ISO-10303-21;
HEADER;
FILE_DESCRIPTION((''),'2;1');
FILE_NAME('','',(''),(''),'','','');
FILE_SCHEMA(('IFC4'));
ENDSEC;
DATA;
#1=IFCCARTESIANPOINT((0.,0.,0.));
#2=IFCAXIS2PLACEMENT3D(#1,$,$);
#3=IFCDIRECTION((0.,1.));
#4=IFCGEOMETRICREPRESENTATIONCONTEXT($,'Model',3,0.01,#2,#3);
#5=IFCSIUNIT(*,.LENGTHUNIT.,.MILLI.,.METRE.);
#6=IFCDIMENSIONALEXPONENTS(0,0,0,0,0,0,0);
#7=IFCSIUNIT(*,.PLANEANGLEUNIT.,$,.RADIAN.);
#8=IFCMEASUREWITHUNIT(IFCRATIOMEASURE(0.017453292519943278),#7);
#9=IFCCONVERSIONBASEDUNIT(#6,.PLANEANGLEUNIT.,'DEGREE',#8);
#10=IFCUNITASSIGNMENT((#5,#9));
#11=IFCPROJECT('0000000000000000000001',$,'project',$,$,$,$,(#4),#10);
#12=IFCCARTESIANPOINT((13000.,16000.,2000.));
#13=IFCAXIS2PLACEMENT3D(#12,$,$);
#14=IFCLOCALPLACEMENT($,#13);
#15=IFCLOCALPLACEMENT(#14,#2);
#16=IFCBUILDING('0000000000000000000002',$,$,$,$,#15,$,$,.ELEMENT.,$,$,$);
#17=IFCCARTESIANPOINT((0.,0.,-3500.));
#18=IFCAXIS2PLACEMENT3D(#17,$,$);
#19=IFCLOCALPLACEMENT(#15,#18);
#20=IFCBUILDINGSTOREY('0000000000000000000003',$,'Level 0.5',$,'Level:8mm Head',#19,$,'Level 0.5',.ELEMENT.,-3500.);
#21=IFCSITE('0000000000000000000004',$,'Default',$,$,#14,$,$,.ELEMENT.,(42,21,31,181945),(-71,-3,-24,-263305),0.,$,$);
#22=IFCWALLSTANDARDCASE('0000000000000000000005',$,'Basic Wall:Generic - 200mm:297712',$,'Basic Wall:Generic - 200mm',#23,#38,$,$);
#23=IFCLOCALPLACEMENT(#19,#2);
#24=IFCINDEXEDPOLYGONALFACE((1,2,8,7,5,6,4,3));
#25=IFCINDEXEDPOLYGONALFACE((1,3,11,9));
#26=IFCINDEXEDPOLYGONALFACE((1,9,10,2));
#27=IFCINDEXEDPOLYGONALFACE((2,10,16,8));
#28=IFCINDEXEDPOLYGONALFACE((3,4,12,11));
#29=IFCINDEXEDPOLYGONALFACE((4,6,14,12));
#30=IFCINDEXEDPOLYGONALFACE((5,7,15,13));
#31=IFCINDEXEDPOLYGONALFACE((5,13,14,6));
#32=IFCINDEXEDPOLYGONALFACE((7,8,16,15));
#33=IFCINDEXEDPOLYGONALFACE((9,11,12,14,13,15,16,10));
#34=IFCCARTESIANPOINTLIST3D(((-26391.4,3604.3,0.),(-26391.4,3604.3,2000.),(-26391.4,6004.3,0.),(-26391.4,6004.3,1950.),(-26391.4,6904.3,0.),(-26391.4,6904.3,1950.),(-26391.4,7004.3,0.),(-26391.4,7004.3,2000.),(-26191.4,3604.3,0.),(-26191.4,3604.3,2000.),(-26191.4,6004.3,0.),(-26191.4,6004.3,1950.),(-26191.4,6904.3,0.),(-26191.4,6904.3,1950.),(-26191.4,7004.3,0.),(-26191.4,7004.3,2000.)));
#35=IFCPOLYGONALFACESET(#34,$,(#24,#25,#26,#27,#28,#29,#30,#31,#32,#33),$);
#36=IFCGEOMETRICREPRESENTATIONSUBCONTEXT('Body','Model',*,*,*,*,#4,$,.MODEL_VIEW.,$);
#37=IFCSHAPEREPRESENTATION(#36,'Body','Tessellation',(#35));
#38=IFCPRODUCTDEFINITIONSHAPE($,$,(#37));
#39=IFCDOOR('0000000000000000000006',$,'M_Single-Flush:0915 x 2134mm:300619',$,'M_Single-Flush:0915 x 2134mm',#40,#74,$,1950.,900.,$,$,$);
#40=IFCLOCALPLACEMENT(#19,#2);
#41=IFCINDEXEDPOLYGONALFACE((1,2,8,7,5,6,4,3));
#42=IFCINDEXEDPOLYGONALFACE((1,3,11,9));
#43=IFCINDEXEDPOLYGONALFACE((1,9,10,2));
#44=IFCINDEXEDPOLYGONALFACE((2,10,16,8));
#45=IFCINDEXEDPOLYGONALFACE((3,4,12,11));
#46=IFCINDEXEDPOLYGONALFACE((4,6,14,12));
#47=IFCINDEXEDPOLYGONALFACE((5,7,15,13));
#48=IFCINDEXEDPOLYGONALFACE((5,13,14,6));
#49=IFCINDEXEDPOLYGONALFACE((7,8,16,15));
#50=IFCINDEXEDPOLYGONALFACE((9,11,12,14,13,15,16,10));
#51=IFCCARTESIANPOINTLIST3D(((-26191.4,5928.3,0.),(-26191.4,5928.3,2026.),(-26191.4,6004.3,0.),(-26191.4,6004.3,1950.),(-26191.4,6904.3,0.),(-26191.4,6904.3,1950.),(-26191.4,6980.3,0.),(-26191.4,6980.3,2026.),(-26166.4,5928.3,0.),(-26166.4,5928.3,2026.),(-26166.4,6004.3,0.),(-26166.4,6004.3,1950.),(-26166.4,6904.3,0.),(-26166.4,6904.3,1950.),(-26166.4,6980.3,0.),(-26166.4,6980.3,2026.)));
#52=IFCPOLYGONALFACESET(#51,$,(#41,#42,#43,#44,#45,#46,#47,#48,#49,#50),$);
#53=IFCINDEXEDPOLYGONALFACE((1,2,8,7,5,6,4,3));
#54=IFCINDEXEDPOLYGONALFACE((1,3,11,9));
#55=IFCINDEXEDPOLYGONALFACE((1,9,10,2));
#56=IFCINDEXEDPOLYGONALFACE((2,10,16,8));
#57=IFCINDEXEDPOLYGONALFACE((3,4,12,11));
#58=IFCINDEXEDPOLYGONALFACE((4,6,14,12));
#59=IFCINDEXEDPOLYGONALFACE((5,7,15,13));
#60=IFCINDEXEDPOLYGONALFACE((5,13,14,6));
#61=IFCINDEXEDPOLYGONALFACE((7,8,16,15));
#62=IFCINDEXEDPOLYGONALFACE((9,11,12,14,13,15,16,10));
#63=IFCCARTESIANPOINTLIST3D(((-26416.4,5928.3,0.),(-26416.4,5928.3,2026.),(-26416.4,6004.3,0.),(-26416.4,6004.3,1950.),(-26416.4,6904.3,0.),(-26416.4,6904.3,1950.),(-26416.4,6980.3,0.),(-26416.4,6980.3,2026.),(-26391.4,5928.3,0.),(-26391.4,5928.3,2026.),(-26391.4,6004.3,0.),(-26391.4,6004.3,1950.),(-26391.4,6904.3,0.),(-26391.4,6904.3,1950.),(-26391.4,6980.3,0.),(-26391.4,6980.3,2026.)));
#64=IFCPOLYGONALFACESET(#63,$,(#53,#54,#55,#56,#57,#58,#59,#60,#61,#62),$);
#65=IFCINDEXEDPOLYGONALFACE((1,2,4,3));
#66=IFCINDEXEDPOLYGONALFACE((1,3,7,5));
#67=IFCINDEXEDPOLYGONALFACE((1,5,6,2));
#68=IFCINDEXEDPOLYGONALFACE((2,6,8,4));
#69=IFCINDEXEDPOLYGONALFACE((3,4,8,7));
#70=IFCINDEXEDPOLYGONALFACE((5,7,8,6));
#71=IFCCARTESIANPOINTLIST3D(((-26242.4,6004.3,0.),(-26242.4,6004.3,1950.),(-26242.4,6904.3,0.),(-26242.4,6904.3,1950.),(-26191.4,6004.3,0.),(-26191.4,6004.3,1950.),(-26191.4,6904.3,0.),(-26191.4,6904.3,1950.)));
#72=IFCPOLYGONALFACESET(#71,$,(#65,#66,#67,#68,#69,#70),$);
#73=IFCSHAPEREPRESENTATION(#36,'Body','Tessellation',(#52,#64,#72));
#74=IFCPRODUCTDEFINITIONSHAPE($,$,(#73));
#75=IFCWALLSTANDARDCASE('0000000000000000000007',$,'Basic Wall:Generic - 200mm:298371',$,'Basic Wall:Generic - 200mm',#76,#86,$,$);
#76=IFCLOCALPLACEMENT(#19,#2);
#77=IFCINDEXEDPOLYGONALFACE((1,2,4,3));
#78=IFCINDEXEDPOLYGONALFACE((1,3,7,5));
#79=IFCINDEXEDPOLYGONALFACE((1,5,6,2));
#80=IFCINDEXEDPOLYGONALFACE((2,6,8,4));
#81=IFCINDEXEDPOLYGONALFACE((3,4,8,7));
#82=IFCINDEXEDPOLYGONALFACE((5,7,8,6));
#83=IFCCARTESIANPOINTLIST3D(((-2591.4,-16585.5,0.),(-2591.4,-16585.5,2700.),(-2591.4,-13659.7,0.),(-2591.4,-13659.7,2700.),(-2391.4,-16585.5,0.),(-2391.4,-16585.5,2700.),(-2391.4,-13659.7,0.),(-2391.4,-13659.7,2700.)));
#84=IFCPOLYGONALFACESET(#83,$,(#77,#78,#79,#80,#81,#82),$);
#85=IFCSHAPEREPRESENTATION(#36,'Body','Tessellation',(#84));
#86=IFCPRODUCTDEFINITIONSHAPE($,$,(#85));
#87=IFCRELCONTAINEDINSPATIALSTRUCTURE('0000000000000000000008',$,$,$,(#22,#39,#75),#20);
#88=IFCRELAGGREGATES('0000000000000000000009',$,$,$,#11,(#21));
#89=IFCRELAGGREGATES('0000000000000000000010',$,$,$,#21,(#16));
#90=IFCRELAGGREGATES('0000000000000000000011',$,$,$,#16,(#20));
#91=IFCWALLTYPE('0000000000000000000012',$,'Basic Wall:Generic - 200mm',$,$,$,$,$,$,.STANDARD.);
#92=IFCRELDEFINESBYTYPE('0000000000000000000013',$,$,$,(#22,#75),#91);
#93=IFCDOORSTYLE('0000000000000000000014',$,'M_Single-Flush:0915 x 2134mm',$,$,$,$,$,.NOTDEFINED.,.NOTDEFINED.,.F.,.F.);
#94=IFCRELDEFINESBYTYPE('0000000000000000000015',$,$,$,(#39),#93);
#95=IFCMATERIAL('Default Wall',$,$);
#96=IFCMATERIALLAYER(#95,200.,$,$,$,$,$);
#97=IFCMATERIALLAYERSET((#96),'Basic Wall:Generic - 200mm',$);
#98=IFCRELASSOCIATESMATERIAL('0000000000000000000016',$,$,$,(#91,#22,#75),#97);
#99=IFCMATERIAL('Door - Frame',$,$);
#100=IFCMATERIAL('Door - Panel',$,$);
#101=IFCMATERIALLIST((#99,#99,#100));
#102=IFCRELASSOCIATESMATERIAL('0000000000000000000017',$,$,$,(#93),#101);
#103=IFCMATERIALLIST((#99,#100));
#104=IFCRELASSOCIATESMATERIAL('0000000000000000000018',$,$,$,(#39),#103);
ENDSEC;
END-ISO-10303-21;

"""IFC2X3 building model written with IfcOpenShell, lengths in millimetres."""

from ifc_helpers import new_model, entity, si_unit, converted_unit, direction, frame, frame_2d, origin, place, context, subcontext, project, spatial, polyline, rectangle, outline, extrude, clip, bounded_halfspace, source, transform, mapped, material, material_list, layer, layer_set, layer_usage, type_object, type_shapes, element, fill, save


model = new_model("IFC2X3")

# Units and contexts
model_context = context("Model", 3, precision=0.01, world=origin(), true_north=direction((0.0, 1.0)))
body_context = subcontext(model_context, "Body", "Model", "MODEL_VIEW")
ifc_project = project(units=[si_unit("LENGTHUNIT", "METRE", prefix="MILLI"), converted_unit("PLANEANGLEUNIT", "DEGREE", entity("IfcRatioMeasure", 0.017453292519943278), si_unit("PLANEANGLEUNIT", "RADIAN"), dimensions=[0, 0, 0, 0, 0, 0, 0])], contexts=[model_context])

# Site, building, storey
site_placement = place(None, frame((13000.0, 16000.0, 2000.0)))
site = spatial("IfcSite", under=ifc_project, at=site_placement, Name="Default", CompositionType="ELEMENT", RefLatitude=(42, 21, 31, 181945), RefLongitude=(-71, -3, -24, -263305), RefElevation=0.0)
building_placement = place(site_placement, origin())
building = spatial("IfcBuilding", under=site, at=building_placement, CompositionType="ELEMENT")
storey_placement = place(building_placement, frame((0.0, 0.0, -3500.0)))
storey = spatial("IfcBuildingStorey", under=building, at=storey_placement, Name="Level 0.5", ObjectType="Level:8mm Head", LongName="Level 0.5", CompositionType="ELEMENT", Elevation=-3500.0)

# Shared definitions
ifc_material_1 = material(Name="Default Wall")
ifc_layer_1 = layer(ifc_material_1, 200.0)
ifc_layer_set_1 = layer_set([ifc_layer_1], Name="Basic Wall:Generic - 200mm")
wall_type_1 = type_object("IfcWallType", Name="Basic Wall:Generic - 200mm", PredefinedType="STANDARD", material=ifc_layer_set_1)

# Wall, opening, door
ifc_layer_usage_1 = layer_usage(ifc_layer_set_1, "AXIS2", "NEGATIVE", 100.0)
wall_1_placement = place(storey_placement, frame((-26291.4, 3604.3, 0.0), z_axis=(0.0, 0.0, 1.0), x_axis=(0.0, 1.0, 0.0)))
wall_1 = element("IfcWallStandardCase", 1, at=wall_1_placement, inside=storey, type_object=wall_type_1, material=ifc_layer_usage_1, Name="Basic Wall:Generic - 200mm:297712", ObjectType="Basic Wall:Generic - 200mm", context=body_context, shape_type="Clipping", body=[
    clip(extrude(rectangle(XDim=3400.0, YDim=200.0, at=frame_2d((1700.0, 0.0), x_axis=(1.0, 0.0))), origin(), (0.0, 0.0, 1.0), 2000.0), bounded_halfspace(frame((0.0, -100.0, 2000.0), z_axis=(0.0, 0.0, -1.0), x_axis=(0.0, -1.0, 0.0)), True, frame((0.0, -100.0, 2000.0)), polyline([(0.0, 0.0), (1036320.0, 0.0), (1036320.0, 60960.0), (0.0, 60960.0), (0.0, 0.0)]))),
])
opening_1_placement = place(wall_1_placement, frame((3300.0, 100.0, 0.0)))
opening_1 = element("IfcOpeningElement", 2, at=opening_1_placement, cuts=wall_1, ObjectType="Opening", context=body_context, shape_type="SweptSolid", body=[
    extrude(rectangle(XDim=900.0, YDim=1950.0, at=frame_2d((975.0, 450.0), x_axis=(0.0, -1.0))), frame((0.0, 0.0, 0.0), z_axis=(0.0, -1.0, 0.0), x_axis=(0.0, 0.0, 1.0)), (0.0, 0.0, 1.0), 200.0),
])
ifc_material_2 = material(Name="Door - Frame")
ifc_material_3 = material(Name="Door - Panel")
ifc_material_list_1 = material_list([ifc_material_2, ifc_material_3])
ifc_material_list_2 = material_list([ifc_material_2, ifc_material_2, ifc_material_3])
door_style_1 = type_object("IfcDoorStyle", Name="M_Single-Flush:0915 x 2134mm", ConstructionType="NOTDEFINED", OperationType="NOTDEFINED", ParameterTakesPrecedence=False, Sizeable=False, material=ifc_material_list_2)
shared_shape_1 = source(origin(), body_context, "Body", "SweptSolid", [
    extrude(outline(polyline([(-526.0, -1032.0), (526.0, -1032.0), (526.0, 994.0), (450.0, 994.0), (450.0, -956.0), (-450.0, -956.0), (-450.0, 994.0), (-526.0, 994.0), (-526.0, -1032.0)])), frame((450.0, 225.0, 994.0), z_axis=(0.0, -1.0, 0.0), x_axis=(-1.0, 0.0, 0.0)), (0.0, 0.0, 1.0), 25.0),
    extrude(outline(polyline([(-1032.0, -526.0), (994.0, -526.0), (994.0, -450.0), (-956.0, -450.0), (-956.0, 450.0), (994.0, 450.0), (994.0, 526.0), (-1032.0, 526.0), (-1032.0, -526.0)])), frame((450.0, 0.0, 994.0), z_axis=(0.0, -1.0, 0.0), x_axis=(0.0, 0.0, -1.0)), (0.0, 0.0, 1.0), 25.0),
    extrude(rectangle(XDim=900.0, YDim=51.0, at=frame_2d((0.0, 0.0), x_axis=(1.0, 0.0))), frame((450.0, 174.5, 0.0)), (0.0, 0.0, 1.0), 1950.0),
])
type_shapes(door_style_1, [shared_shape_1])
door_1_placement = place(opening_1_placement, frame((0.0, 0.0, 0.0), z_axis=(0.0, 0.0, 1.0), x_axis=(-1.0, 0.0, 0.0)))
door_1 = element("IfcDoor", 3, at=door_1_placement, inside=storey, type_object=door_style_1, material=ifc_material_list_1, Name="M_Single-Flush:0915 x 2134mm:300619", ObjectType="M_Single-Flush:0915 x 2134mm", OverallHeight=1950.0, OverallWidth=900.0, context=body_context, shape_type="MappedRepresentation", body=[
    mapped(shared_shape_1, transform((0.0, 0.0, 0.0), scale=1.0)),
])
fill(opening_1, door_1)

# Wall
ifc_layer_usage_2 = layer_usage(ifc_layer_set_1, "AXIS2", "NEGATIVE", 100.0)
wall_2_placement = place(storey_placement, frame((-2491.4, -16585.5, 0.0), z_axis=(0.0, 0.0, 1.0), x_axis=(0.0, 1.0, 0.0)))
element("IfcWallStandardCase", 4, at=wall_2_placement, inside=storey, type_object=wall_type_1, material=ifc_layer_usage_2, Name="Basic Wall:Generic - 200mm:298371", ObjectType="Basic Wall:Generic - 200mm", context=body_context, shape_type="SweptSolid", body=[
    extrude(rectangle(XDim=2925.8, YDim=200.0, at=frame_2d((1462.9, 0.0), x_axis=(-1.0, 0.0))), origin(), (0.0, 0.0, 1.0), 2700.0),
])

save(model, "model.ifc")
